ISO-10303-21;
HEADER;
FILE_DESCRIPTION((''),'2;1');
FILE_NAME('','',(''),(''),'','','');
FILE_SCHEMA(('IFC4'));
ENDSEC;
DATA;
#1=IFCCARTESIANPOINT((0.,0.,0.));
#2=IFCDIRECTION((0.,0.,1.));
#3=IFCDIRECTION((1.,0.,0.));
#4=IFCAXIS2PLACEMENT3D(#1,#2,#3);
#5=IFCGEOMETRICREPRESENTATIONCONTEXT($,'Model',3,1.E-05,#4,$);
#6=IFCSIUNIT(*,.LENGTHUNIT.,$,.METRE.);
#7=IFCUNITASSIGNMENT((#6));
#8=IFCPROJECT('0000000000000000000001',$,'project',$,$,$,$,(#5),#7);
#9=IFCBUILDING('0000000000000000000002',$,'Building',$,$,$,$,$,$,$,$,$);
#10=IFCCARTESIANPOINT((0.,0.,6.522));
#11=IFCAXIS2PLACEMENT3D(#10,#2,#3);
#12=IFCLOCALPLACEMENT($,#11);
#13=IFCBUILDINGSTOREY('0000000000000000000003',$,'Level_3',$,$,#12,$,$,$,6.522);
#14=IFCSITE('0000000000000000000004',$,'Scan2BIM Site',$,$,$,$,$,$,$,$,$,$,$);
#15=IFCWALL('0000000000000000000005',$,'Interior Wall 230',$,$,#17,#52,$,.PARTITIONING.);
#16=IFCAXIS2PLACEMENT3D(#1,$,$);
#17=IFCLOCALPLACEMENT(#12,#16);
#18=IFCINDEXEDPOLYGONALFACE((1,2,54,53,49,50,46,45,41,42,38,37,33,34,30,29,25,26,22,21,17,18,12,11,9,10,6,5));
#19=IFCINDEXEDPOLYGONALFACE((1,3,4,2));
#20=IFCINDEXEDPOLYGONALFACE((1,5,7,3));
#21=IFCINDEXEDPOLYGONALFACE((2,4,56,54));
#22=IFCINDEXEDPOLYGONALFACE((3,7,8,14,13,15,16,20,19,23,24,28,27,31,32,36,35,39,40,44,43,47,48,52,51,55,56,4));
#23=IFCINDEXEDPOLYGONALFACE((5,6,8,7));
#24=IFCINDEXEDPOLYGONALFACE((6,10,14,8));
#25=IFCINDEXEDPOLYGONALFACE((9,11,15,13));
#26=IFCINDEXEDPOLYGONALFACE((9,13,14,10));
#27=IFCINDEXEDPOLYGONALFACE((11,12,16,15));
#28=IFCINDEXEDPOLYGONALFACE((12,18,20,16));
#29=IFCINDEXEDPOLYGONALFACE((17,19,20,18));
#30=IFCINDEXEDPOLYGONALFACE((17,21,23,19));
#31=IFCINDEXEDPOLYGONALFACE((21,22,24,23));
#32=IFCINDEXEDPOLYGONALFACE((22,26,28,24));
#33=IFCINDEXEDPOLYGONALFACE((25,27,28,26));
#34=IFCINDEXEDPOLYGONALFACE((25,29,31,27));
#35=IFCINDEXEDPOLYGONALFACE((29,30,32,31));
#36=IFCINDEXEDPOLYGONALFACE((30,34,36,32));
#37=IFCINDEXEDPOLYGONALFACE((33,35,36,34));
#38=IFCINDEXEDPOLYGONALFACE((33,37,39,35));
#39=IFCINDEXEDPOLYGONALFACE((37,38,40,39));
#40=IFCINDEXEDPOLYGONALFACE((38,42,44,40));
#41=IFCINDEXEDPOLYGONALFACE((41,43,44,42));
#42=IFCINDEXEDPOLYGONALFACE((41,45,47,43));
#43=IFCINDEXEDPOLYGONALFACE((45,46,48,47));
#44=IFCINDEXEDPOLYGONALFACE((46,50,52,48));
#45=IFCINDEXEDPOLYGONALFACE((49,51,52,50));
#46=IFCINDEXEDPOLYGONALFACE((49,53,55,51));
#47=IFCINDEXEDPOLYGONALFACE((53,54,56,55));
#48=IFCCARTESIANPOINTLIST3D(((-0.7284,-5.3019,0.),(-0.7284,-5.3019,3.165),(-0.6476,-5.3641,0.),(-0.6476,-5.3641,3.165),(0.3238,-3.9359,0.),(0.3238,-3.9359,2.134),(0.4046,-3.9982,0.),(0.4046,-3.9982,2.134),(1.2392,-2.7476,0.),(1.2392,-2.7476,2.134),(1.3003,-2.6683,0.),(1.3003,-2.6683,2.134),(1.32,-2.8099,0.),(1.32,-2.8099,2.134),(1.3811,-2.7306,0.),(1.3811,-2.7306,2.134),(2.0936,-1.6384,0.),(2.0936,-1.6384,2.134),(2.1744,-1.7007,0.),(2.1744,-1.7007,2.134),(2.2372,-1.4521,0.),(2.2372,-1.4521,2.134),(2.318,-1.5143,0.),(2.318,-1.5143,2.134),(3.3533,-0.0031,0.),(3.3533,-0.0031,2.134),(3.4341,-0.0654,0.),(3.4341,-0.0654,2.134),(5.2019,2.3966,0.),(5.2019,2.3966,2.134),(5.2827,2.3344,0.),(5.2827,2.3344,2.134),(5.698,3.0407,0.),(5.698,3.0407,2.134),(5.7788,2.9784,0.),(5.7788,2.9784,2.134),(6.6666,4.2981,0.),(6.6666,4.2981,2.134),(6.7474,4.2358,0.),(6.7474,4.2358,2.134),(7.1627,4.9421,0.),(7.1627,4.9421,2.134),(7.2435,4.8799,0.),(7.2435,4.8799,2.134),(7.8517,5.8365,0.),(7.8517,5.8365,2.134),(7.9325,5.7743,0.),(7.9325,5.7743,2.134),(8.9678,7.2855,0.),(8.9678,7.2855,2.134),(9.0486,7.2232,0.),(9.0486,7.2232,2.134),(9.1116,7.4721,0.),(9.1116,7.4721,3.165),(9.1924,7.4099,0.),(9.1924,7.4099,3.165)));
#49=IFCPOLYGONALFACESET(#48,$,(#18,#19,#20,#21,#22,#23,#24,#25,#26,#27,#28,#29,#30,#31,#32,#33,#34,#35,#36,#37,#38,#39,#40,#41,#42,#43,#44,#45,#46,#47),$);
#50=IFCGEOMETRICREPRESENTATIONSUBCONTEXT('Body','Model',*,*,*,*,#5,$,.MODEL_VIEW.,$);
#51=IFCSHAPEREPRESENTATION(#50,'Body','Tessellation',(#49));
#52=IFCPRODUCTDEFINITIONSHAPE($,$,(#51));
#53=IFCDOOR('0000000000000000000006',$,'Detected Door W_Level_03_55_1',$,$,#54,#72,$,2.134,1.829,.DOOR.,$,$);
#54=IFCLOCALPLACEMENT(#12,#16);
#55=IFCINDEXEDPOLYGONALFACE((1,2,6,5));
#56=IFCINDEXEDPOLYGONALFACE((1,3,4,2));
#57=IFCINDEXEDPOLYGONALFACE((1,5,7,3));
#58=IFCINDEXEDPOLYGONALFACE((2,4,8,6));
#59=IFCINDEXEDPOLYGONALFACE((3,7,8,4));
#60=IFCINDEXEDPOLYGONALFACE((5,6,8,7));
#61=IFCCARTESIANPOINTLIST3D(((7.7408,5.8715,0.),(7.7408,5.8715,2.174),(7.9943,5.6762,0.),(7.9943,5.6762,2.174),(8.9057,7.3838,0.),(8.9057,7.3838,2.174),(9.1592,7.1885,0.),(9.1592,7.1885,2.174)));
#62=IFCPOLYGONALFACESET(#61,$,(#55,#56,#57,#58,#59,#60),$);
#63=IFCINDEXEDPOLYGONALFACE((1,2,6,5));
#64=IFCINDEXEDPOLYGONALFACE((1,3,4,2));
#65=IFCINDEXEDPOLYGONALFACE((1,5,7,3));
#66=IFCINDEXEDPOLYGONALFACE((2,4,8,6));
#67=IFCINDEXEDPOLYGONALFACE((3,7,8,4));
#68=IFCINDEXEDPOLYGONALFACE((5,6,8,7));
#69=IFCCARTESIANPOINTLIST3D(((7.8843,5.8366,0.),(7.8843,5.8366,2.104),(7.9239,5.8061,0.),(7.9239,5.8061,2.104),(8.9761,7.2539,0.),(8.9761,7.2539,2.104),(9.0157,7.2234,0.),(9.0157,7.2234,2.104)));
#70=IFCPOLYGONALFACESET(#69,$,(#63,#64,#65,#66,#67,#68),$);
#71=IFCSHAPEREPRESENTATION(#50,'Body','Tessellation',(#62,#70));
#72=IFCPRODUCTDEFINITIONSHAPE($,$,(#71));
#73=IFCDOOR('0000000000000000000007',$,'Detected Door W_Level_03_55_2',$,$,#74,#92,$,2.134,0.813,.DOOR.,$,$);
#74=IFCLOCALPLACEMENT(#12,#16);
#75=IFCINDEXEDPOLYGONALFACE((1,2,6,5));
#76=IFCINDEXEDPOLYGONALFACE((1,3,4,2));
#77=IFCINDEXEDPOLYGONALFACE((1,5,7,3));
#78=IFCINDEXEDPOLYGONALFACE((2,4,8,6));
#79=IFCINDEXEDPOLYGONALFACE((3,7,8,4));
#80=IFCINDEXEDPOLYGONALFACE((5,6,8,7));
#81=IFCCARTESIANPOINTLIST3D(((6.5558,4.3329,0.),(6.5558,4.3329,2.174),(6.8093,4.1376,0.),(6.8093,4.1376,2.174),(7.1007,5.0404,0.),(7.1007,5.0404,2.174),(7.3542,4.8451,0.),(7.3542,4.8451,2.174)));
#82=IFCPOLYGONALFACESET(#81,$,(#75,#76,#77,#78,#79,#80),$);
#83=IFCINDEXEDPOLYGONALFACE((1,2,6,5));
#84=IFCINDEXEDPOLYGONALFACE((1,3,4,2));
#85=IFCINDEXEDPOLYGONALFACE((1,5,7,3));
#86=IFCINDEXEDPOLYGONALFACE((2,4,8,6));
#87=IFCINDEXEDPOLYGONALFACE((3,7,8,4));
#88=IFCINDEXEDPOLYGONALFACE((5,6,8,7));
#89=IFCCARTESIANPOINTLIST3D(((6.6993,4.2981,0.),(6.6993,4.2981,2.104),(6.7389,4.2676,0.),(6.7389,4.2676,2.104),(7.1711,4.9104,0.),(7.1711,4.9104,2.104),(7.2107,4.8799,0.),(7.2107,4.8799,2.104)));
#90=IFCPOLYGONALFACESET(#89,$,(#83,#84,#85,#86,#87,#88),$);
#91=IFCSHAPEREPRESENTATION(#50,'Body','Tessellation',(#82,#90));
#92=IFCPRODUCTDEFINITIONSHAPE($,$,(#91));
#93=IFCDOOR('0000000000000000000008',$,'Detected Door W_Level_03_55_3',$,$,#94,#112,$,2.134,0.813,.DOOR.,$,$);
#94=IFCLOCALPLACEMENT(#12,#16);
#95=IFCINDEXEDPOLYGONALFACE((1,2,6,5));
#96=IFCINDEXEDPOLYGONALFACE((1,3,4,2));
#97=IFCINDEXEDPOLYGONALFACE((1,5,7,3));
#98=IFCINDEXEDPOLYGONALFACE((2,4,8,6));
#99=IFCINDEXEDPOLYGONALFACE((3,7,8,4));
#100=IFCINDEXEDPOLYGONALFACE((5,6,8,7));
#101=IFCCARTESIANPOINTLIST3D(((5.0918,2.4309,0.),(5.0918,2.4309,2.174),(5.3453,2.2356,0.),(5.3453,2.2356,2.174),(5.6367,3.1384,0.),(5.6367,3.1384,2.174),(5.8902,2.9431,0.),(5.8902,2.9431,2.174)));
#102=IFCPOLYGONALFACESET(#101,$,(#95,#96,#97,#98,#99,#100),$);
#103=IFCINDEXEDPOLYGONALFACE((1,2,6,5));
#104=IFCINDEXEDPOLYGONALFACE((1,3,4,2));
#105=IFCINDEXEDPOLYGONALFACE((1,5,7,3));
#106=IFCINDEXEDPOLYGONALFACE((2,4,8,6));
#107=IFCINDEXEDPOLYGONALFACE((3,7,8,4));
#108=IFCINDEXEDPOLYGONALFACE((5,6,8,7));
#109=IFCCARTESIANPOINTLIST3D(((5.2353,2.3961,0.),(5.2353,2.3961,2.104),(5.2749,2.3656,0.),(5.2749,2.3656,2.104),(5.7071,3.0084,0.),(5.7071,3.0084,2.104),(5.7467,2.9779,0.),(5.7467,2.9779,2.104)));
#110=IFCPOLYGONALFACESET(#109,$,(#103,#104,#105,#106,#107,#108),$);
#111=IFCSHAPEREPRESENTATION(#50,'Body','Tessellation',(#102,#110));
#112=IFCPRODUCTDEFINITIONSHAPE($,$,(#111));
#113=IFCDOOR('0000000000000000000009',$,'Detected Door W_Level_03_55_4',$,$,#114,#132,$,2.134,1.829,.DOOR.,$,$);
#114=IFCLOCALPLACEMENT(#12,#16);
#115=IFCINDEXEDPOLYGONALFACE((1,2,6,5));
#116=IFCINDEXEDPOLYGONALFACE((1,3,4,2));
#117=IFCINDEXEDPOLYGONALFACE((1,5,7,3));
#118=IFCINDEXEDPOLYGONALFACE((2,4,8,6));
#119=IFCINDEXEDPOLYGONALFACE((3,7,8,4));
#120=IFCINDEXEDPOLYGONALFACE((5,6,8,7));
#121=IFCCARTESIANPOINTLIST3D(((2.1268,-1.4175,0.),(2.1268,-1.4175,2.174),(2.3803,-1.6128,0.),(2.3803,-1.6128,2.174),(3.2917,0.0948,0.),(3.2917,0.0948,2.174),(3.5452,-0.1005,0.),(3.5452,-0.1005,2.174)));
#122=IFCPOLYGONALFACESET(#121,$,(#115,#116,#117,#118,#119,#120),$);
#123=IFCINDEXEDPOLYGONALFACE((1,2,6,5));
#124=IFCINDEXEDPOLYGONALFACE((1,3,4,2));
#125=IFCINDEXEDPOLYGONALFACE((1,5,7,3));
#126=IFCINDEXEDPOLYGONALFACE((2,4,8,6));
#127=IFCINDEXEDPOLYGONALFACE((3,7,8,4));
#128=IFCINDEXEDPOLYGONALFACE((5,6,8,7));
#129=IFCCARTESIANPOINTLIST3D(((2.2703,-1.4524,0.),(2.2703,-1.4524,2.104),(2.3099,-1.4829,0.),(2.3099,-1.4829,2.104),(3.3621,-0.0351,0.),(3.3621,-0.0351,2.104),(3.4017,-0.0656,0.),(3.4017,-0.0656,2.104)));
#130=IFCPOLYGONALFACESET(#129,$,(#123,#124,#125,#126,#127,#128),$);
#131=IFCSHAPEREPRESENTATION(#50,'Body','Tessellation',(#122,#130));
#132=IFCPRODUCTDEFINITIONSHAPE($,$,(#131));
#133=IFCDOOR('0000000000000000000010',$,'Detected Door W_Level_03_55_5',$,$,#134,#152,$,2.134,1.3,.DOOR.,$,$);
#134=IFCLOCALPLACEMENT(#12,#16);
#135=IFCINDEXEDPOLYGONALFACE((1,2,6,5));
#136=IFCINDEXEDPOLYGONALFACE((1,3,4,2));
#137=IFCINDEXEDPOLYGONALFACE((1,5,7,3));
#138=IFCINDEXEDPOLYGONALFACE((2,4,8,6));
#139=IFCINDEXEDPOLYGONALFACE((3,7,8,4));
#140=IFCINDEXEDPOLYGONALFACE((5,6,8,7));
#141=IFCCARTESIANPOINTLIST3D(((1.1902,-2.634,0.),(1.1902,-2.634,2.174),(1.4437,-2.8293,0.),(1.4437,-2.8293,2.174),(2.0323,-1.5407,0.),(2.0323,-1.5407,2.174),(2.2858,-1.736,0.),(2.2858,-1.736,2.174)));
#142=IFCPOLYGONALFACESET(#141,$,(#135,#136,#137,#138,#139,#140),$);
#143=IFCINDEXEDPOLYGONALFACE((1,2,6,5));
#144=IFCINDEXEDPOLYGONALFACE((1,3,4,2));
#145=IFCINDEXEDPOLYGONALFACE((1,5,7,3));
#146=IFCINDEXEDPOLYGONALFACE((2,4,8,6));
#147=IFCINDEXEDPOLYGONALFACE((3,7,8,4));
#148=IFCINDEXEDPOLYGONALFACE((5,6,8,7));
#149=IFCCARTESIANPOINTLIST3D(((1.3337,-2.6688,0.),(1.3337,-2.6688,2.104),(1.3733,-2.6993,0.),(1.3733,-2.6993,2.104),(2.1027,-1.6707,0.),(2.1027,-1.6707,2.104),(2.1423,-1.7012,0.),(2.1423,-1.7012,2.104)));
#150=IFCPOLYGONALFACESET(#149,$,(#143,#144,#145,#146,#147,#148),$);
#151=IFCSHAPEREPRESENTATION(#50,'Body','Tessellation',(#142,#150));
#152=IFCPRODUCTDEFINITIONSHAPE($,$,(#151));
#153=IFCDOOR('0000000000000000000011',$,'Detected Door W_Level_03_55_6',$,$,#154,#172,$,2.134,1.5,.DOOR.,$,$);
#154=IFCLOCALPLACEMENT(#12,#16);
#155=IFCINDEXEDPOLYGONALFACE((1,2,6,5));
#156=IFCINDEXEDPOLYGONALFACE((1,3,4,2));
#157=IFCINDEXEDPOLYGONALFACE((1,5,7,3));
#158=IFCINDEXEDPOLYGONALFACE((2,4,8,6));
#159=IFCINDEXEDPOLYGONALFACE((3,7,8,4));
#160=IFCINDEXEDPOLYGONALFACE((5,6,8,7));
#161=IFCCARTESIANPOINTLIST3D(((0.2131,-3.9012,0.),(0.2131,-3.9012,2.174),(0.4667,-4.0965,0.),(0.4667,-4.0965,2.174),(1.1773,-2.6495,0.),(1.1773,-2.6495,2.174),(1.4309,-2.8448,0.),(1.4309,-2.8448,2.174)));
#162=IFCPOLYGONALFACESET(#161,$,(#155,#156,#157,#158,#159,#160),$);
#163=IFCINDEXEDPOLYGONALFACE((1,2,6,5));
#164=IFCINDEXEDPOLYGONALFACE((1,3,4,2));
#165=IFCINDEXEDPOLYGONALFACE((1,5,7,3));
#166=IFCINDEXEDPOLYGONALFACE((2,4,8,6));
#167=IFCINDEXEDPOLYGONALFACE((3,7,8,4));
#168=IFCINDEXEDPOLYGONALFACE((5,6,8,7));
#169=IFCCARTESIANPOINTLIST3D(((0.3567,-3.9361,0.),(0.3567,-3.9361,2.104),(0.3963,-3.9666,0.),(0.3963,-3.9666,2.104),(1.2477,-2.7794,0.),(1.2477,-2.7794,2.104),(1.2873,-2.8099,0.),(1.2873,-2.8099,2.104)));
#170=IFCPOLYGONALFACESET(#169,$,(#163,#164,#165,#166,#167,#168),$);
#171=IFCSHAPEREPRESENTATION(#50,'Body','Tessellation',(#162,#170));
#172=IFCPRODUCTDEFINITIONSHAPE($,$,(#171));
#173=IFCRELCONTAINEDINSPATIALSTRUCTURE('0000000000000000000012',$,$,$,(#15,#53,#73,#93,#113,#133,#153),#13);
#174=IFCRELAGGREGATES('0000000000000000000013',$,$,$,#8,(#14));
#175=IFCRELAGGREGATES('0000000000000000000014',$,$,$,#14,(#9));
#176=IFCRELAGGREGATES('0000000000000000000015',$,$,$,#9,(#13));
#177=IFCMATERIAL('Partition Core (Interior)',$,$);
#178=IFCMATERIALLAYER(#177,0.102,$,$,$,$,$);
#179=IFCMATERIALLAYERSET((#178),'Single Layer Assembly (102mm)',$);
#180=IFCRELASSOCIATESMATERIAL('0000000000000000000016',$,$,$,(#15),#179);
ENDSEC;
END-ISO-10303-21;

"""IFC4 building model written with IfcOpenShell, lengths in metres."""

from ifc_helpers import new_model, si_unit, frame, origin, origin_with_axes, place, context, subcontext, project, spatial, rectangle, extrude, material, layer, layer_set, element, fill, save


model = new_model("IFC4")

# Units and contexts
model_context = context("Model", 3, precision=1e-05, world=origin_with_axes())
body_context = subcontext(model_context, "Body", "Model", "MODEL_VIEW")
ifc_project = project(units=[si_unit("LENGTHUNIT", "METRE")], contexts=[model_context])

# Site, building, storey
site = spatial("IfcSite", under=ifc_project, Name="Scan2BIM Site")
building = spatial("IfcBuilding", under=site, Name="Building")
storey_placement = place(None, frame((0.0, 0.0, 6.522), z_axis=(0.0, 0.0, 1.0), x_axis=(1.0, 0.0, 0.0)))
storey = spatial("IfcBuildingStorey", under=building, at=storey_placement, Name="Level_3", Elevation=6.522)

# Wall, openings, doors
ifc_material_1 = material(Name="Partition Core (Interior)")
ifc_layer_1 = layer(ifc_material_1, 0.102)
ifc_layer_set_1 = layer_set([ifc_layer_1], Name="Single Layer Assembly (102mm)")
wall_1_placement = place(storey_placement, frame((4.232, 1.054, 0.0), z_axis=(0.0, 0.0, 1.0), x_axis=(-0.61025, -0.792209, 0.0)))
wall_1 = element("IfcWall", 1, at=wall_1_placement, inside=storey, material=ifc_layer_set_1, Name="Interior Wall 230", PredefinedType="PARTITIONING", context=body_context, shape_type="SweptSolid", body=[
    extrude(rectangle(XDim=16.1245, YDim=0.102), origin(), (0.0, 0.0, 1.0), 3.165),
])
opening_1_placement = place(None, frame((8.45, 6.53, 6.522), z_axis=(0.0, 0.0, 1.0), x_axis=(-0.61025, -0.792209, 0.0)))
opening_1 = element("IfcOpeningElement", 2, at=opening_1_placement, cuts=wall_1, PredefinedType="OPENING", context=body_context, shape_type="SweptSolid", body=[
    extrude(rectangle(XDim=1.829, YDim=0.202), origin(), (0.0, 0.0, 1.0), 2.134),
])
opening_2_placement = place(None, frame((6.955, 4.589, 6.522), z_axis=(0.0, 0.0, 1.0), x_axis=(-0.61025, -0.792209, 0.0)))
opening_2 = element("IfcOpeningElement", 3, at=opening_2_placement, cuts=wall_1, PredefinedType="OPENING", context=body_context, shape_type="SweptSolid", body=[
    extrude(rectangle(XDim=0.813, YDim=0.202), origin(), (0.0, 0.0, 1.0), 2.134),
])
opening_3_placement = place(None, frame((5.491, 2.687, 6.522), z_axis=(0.0, 0.0, 1.0), x_axis=(-0.61025, -0.792209, 0.0)))
opening_3 = element("IfcOpeningElement", 4, at=opening_3_placement, cuts=wall_1, PredefinedType="OPENING", context=body_context, shape_type="SweptSolid", body=[
    extrude(rectangle(XDim=0.813, YDim=0.202), origin(), (0.0, 0.0, 1.0), 2.134),
])
opening_4_placement = place(None, frame((2.836, -0.759, 6.522), z_axis=(0.0, 0.0, 1.0), x_axis=(-0.61025, -0.792209, 0.0)))
opening_4 = element("IfcOpeningElement", 5, at=opening_4_placement, cuts=wall_1, PredefinedType="OPENING", context=body_context, shape_type="SweptSolid", body=[
    extrude(rectangle(XDim=1.829, YDim=0.202), origin(), (0.0, 0.0, 1.0), 2.134),
])
opening_5_placement = place(None, frame((1.738, -2.185, 6.522), z_axis=(0.0, 0.0, 1.0), x_axis=(-0.61025, -0.792209, 0.0)))
opening_5 = element("IfcOpeningElement", 6, at=opening_5_placement, cuts=wall_1, PredefinedType="OPENING", context=body_context, shape_type="SweptSolid", body=[
    extrude(rectangle(XDim=1.3, YDim=0.202), origin(), (0.0, 0.0, 1.0), 2.134),
])
opening_6_placement = place(None, frame((0.822, -3.373, 6.522), z_axis=(0.0, 0.0, 1.0), x_axis=(-0.61025, -0.792209, 0.0)))
opening_6 = element("IfcOpeningElement", 7, at=opening_6_placement, cuts=wall_1, PredefinedType="OPENING", context=body_context, shape_type="SweptSolid", body=[
    extrude(rectangle(XDim=1.5, YDim=0.202), origin(), (0.0, 0.0, 1.0), 2.134),
])
door_1_placement = place(opening_1_placement, frame((0.0, 0.0, 0.0), z_axis=(0.0, 0.0, 1.0), x_axis=(1.0, 0.0, 0.0)))
door_1 = element("IfcDoor", 8, at=door_1_placement, inside=storey, Name="Detected Door W_Level_03_55_1", OverallHeight=2.134, OverallWidth=1.829, PredefinedType="DOOR", context=body_context, shape_type="SweptSolid", body=[
    extrude(rectangle(XDim=1.909, YDim=0.32), origin(), (0.0, 0.0, 1.0), 2.174),
    extrude(rectangle(XDim=1.789, YDim=0.05), origin(), (0.0, 0.0, 1.0), 2.104),
])
fill(opening_1, door_1)
door_2_placement = place(opening_2_placement, frame((0.0, 0.0, 0.0), z_axis=(0.0, 0.0, 1.0), x_axis=(1.0, 0.0, 0.0)))
door_2 = element("IfcDoor", 9, at=door_2_placement, inside=storey, Name="Detected Door W_Level_03_55_2", OverallHeight=2.134, OverallWidth=0.813, PredefinedType="DOOR", context=body_context, shape_type="SweptSolid", body=[
    extrude(rectangle(XDim=0.893, YDim=0.32), origin(), (0.0, 0.0, 1.0), 2.174),
    extrude(rectangle(XDim=0.773, YDim=0.05), origin(), (0.0, 0.0, 1.0), 2.104),
])
fill(opening_2, door_2)
door_3_placement = place(opening_3_placement, frame((0.0, 0.0, 0.0), z_axis=(0.0, 0.0, 1.0), x_axis=(1.0, 0.0, 0.0)))
door_3 = element("IfcDoor", 10, at=door_3_placement, inside=storey, Name="Detected Door W_Level_03_55_3", OverallHeight=2.134, OverallWidth=0.813, PredefinedType="DOOR", context=body_context, shape_type="SweptSolid", body=[
    extrude(rectangle(XDim=0.893, YDim=0.32), origin(), (0.0, 0.0, 1.0), 2.174),
    extrude(rectangle(XDim=0.773, YDim=0.05), origin(), (0.0, 0.0, 1.0), 2.104),
])
fill(opening_3, door_3)
door_4_placement = place(opening_4_placement, frame((0.0, 0.0, 0.0), z_axis=(0.0, 0.0, 1.0), x_axis=(1.0, 0.0, 0.0)))
door_4 = element("IfcDoor", 11, at=door_4_placement, inside=storey, Name="Detected Door W_Level_03_55_4", OverallHeight=2.134, OverallWidth=1.829, PredefinedType="DOOR", context=body_context, shape_type="SweptSolid", body=[
    extrude(rectangle(XDim=1.909, YDim=0.32), origin(), (0.0, 0.0, 1.0), 2.174),
    extrude(rectangle(XDim=1.789, YDim=0.05), origin(), (0.0, 0.0, 1.0), 2.104),
])
fill(opening_4, door_4)
door_5_placement = place(opening_5_placement, frame((0.0, 0.0, 0.0), z_axis=(0.0, 0.0, 1.0), x_axis=(1.0, 0.0, 0.0)))
door_5 = element("IfcDoor", 12, at=door_5_placement, inside=storey, Name="Detected Door W_Level_03_55_5", OverallHeight=2.134, OverallWidth=1.3, PredefinedType="DOOR", context=body_context, shape_type="SweptSolid", body=[
    extrude(rectangle(XDim=1.38, YDim=0.32), origin(), (0.0, 0.0, 1.0), 2.174),
    extrude(rectangle(XDim=1.26, YDim=0.05), origin(), (0.0, 0.0, 1.0), 2.104),
])
fill(opening_5, door_5)
door_6_placement = place(opening_6_placement, frame((0.0, 0.0, 0.0), z_axis=(0.0, 0.0, 1.0), x_axis=(1.0, 0.0, 0.0)))
door_6 = element("IfcDoor", 13, at=door_6_placement, inside=storey, Name="Detected Door W_Level_03_55_6", OverallHeight=2.134, OverallWidth=1.5, PredefinedType="DOOR", context=body_context, shape_type="SweptSolid", body=[
    extrude(rectangle(XDim=1.58, YDim=0.32), origin(), (0.0, 0.0, 1.0), 2.174),
    extrude(rectangle(XDim=1.46, YDim=0.05), origin(), (0.0, 0.0, 1.0), 2.104),
])
fill(opening_6, door_6)

save(model, "model.ifc")
